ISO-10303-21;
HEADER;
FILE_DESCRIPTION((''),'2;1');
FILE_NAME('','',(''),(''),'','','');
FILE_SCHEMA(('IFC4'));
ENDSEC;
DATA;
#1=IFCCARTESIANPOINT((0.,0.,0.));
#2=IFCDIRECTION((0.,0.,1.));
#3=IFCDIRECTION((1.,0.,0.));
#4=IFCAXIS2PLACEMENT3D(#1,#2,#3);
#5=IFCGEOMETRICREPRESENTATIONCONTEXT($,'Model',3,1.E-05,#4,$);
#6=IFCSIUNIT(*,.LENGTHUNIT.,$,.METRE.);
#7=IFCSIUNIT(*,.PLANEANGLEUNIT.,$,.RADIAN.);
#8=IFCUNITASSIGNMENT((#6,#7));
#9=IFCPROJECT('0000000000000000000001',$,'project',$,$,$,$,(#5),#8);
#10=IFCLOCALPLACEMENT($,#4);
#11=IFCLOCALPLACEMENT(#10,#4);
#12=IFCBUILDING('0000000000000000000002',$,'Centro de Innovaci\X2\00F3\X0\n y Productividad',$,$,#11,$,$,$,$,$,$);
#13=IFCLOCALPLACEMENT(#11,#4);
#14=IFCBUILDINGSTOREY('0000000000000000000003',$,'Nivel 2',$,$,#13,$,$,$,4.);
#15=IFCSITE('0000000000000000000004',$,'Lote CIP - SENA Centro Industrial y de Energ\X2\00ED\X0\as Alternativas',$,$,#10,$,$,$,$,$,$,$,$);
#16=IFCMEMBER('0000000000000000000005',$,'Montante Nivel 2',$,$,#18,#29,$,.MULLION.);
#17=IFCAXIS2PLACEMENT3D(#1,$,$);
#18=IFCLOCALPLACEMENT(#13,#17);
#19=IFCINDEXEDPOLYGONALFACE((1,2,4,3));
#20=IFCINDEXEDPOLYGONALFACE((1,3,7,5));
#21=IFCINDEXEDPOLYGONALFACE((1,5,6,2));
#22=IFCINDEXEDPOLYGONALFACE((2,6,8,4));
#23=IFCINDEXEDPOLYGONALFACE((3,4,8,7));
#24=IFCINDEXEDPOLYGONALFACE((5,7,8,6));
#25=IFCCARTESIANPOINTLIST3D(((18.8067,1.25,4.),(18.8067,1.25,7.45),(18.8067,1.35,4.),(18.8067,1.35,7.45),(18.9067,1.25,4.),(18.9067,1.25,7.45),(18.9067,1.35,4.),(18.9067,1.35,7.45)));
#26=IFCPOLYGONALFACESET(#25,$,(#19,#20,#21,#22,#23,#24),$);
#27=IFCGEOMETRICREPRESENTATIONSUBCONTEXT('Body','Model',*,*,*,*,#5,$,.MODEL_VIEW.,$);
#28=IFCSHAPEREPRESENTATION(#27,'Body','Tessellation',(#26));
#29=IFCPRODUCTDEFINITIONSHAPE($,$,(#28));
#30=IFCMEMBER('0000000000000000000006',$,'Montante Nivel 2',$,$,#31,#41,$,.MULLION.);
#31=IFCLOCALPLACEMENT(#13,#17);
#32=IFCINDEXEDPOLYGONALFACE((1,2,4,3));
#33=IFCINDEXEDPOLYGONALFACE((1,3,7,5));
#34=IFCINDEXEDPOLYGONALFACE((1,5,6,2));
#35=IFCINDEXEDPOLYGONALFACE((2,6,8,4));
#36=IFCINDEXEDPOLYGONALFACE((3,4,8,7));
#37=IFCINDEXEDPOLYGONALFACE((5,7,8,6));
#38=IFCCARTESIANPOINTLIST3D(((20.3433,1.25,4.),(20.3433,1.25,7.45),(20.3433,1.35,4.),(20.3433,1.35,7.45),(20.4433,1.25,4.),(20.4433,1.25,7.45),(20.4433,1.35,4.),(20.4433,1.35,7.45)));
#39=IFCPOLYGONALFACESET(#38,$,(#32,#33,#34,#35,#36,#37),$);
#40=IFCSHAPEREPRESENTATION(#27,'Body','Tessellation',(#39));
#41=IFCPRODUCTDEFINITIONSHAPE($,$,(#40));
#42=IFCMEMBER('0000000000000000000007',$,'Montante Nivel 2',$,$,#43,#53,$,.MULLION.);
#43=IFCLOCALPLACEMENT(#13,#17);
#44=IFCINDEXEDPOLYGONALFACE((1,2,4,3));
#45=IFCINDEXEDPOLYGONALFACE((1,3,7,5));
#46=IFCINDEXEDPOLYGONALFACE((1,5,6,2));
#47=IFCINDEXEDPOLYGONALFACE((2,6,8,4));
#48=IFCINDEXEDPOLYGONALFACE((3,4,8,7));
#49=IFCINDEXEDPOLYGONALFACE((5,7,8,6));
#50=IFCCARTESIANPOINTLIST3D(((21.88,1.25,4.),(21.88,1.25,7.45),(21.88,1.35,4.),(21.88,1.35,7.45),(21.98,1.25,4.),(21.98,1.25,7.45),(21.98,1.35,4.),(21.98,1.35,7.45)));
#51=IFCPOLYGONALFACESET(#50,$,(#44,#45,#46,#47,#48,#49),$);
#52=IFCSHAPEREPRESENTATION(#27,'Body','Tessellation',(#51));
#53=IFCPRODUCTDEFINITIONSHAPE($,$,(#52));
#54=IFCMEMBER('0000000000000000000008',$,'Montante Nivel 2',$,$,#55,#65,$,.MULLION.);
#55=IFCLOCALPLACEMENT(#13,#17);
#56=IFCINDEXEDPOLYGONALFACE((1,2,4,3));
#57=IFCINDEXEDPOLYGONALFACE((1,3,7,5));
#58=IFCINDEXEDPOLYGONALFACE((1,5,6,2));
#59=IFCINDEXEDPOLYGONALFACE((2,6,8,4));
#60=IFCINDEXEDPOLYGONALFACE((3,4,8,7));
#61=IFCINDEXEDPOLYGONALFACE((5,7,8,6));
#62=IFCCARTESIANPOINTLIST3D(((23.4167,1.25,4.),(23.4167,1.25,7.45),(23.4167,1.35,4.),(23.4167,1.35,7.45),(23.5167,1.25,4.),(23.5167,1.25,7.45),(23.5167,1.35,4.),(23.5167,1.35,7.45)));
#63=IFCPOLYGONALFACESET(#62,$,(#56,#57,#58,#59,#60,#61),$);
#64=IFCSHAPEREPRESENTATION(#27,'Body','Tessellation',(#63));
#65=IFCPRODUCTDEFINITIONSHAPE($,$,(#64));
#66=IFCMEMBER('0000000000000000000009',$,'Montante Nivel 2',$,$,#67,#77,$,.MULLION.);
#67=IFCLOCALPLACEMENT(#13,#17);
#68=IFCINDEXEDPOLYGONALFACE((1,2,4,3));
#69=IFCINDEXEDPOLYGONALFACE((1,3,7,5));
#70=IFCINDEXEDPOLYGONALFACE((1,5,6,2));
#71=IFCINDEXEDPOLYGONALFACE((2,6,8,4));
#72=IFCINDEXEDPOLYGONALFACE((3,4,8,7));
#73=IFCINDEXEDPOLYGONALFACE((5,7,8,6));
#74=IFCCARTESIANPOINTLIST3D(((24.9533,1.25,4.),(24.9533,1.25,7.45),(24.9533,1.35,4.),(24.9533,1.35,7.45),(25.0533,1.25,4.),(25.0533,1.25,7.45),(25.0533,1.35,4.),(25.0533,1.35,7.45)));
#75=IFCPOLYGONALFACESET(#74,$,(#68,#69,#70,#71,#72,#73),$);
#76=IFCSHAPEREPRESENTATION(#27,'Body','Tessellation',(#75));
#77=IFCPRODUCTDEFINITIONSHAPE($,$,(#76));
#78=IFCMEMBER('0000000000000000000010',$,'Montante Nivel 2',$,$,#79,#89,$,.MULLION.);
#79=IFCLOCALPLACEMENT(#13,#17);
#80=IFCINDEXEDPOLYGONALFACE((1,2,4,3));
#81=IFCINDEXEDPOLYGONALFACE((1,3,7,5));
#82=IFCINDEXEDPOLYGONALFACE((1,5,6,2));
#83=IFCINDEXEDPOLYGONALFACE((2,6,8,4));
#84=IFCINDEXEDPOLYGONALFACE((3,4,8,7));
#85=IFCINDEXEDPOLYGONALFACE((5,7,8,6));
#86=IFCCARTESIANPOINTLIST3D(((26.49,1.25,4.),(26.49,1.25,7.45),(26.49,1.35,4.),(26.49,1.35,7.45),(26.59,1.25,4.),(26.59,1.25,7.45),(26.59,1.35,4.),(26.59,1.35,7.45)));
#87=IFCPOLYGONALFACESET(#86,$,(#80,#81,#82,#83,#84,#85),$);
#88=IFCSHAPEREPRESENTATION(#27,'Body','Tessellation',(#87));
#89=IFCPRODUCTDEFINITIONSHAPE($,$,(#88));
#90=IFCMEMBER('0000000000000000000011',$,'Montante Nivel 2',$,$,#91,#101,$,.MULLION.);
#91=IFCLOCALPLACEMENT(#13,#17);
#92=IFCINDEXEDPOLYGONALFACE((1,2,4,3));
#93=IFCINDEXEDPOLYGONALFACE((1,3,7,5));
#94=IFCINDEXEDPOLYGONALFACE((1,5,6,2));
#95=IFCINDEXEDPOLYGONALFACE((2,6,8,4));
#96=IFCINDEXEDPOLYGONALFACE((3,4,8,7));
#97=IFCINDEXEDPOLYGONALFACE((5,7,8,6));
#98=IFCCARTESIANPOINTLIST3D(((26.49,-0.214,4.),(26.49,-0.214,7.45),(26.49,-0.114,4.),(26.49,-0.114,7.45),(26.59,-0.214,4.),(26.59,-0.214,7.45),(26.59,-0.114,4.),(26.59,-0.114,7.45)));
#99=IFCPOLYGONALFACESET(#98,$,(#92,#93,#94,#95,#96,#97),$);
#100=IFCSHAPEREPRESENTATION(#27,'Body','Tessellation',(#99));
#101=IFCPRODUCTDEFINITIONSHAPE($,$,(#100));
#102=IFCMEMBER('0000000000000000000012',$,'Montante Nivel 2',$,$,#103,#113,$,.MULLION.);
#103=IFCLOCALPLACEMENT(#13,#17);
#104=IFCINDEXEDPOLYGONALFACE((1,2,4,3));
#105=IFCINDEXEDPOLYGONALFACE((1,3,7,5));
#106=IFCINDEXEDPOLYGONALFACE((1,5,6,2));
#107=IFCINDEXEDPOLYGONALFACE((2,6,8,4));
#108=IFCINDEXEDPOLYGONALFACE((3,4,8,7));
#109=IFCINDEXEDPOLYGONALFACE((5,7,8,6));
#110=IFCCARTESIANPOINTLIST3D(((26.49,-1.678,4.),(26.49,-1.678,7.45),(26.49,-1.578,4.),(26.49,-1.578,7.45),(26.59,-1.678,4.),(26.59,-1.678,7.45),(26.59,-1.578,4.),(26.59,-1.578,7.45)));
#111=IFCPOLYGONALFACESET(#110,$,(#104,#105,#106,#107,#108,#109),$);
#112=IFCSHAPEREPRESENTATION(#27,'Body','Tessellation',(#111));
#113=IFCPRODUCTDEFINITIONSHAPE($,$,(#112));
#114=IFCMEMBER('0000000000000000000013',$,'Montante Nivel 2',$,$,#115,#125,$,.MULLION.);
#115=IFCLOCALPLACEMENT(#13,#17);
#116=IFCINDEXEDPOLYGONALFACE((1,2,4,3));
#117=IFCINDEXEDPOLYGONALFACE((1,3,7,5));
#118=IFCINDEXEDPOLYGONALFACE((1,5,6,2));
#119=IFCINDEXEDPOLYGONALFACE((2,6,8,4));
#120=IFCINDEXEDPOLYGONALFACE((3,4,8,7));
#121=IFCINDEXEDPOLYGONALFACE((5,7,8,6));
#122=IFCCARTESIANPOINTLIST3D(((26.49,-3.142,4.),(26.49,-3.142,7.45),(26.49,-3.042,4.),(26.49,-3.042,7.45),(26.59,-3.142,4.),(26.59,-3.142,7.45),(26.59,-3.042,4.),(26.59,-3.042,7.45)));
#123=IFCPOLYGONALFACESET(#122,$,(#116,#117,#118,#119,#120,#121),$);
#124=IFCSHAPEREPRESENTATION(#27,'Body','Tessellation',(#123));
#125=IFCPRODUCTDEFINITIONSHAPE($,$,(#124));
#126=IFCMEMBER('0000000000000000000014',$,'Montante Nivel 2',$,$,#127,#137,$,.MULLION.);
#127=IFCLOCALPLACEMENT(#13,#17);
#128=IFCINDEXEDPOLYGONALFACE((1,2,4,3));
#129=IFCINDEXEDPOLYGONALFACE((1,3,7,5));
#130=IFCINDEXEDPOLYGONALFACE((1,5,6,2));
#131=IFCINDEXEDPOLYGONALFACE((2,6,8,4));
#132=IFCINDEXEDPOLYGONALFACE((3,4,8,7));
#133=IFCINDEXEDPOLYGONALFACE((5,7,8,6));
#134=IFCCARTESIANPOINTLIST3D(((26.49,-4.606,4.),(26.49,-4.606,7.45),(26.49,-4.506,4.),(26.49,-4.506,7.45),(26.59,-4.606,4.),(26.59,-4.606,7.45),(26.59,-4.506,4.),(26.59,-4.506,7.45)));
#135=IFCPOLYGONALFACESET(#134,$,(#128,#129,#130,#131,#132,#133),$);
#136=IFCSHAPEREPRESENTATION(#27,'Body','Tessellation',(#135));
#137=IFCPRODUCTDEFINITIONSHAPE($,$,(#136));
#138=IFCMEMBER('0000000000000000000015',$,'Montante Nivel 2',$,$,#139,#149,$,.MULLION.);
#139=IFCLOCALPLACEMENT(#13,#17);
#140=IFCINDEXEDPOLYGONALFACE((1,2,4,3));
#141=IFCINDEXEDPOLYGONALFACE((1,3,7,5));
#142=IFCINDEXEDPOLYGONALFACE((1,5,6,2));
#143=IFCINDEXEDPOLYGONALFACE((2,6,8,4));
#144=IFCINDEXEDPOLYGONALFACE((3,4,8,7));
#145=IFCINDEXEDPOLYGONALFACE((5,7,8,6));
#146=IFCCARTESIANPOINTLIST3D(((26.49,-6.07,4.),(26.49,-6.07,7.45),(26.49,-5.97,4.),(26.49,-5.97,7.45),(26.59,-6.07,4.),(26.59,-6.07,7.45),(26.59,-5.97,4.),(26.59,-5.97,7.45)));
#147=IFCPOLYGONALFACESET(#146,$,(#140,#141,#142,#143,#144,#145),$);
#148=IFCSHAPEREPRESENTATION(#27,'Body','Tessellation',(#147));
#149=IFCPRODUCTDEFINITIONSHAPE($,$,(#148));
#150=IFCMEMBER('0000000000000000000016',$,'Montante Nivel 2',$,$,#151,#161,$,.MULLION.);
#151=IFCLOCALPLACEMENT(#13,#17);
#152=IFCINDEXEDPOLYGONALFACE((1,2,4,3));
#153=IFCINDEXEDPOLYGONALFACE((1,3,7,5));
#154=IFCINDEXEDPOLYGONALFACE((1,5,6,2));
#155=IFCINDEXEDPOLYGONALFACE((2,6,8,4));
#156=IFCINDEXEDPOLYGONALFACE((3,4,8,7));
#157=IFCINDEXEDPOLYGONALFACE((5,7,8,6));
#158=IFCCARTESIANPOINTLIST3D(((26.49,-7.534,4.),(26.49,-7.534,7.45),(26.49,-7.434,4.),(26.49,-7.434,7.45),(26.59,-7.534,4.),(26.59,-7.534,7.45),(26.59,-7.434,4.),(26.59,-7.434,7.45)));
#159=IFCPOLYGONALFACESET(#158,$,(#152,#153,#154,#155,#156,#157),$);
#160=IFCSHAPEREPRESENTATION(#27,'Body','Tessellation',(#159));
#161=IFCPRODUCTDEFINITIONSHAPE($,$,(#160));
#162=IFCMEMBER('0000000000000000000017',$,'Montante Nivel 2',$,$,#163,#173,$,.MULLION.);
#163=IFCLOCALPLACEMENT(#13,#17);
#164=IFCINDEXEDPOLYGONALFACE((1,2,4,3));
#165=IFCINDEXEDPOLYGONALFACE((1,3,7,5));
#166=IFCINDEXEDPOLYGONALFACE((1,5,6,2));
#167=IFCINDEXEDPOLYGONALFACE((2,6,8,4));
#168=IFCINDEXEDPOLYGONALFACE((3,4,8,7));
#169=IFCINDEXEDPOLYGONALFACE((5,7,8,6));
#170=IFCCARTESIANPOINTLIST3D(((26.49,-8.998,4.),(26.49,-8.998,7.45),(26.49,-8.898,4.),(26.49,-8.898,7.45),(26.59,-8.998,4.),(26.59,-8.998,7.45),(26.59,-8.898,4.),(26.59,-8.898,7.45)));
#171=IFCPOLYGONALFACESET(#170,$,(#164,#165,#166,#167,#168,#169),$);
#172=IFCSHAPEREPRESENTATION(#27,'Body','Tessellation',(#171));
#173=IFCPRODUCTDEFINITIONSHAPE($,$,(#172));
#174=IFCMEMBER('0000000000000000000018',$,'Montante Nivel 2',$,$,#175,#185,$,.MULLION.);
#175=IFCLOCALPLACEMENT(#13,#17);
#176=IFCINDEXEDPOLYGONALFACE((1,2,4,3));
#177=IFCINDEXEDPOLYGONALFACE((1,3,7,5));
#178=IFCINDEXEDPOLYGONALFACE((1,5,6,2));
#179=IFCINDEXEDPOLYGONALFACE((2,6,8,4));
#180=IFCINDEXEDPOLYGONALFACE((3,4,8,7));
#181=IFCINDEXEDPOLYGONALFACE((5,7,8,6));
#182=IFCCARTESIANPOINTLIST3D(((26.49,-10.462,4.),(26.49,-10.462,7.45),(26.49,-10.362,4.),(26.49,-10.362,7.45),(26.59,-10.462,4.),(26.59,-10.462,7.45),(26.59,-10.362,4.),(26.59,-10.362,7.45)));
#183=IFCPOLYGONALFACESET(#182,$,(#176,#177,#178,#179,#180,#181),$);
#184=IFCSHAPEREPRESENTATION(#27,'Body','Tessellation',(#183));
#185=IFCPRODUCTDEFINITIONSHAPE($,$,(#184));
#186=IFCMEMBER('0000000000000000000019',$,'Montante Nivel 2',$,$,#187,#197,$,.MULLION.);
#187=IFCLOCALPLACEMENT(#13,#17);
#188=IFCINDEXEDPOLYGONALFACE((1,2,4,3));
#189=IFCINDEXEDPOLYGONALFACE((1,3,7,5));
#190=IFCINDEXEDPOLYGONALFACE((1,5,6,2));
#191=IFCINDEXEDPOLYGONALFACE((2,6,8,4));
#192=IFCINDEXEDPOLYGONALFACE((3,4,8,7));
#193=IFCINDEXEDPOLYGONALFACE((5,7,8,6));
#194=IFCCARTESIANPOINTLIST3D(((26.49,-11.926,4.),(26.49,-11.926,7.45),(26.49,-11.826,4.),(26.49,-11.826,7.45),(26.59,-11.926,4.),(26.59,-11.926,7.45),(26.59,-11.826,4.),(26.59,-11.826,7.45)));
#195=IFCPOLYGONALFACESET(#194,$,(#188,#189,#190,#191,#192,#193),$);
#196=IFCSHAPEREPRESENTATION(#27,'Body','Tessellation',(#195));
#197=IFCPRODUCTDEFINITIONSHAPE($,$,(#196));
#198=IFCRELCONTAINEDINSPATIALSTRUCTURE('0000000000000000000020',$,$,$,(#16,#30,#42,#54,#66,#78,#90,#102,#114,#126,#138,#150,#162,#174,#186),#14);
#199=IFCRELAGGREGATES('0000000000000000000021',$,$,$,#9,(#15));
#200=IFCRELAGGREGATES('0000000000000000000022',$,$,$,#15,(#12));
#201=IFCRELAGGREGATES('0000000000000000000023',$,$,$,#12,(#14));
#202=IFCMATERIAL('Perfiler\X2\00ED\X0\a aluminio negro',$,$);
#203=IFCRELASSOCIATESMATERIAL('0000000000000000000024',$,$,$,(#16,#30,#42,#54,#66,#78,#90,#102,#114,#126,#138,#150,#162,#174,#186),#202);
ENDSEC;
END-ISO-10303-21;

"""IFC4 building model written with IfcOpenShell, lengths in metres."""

from ifc_helpers import new_model, si_unit, frame, origin_with_axes, place, context, subcontext, project, spatial, polyline, outline, extrude, material, element, save


model = new_model("IFC4")

# Units and contexts
model_context = context("Model", 3, precision=1e-05, world=origin_with_axes())
body_context = subcontext(model_context, "Body", "Model", "MODEL_VIEW")
ifc_project = project(units=[si_unit("LENGTHUNIT", "METRE"), si_unit("PLANEANGLEUNIT", "RADIAN")], contexts=[model_context])

# Site, building, storey
site_placement = place(None, origin_with_axes())
site = spatial("IfcSite", under=ifc_project, at=site_placement, Name="Lote CIP - SENA Centro Industrial y de Energías Alternativas")
building_placement = place(site_placement, origin_with_axes())
building = spatial("IfcBuilding", under=site, at=building_placement, Name="Centro de Innovación y Productividad")
storey_placement = place(building_placement, origin_with_axes())
storey = spatial("IfcBuildingStorey", under=building, at=storey_placement, Name="Nivel 2", Elevation=4.0)

# Members
ifc_material_1 = material(Name="Perfilería aluminio negro")
member_1_placement = place(storey_placement, origin_with_axes())
element("IfcMember", 1, at=member_1_placement, inside=storey, material=ifc_material_1, Name="Montante Nivel 2", PredefinedType="MULLION", context=body_context, shape_type="SweptSolid", body=[
    extrude(outline(polyline([(18.9067, 1.35), (18.9067, 1.25), (18.8067, 1.25), (18.8067, 1.35), (18.9067, 1.35)])), frame((0.0, 0.0, 4.0)), (0.0, 0.0, 1.0), 3.45),
])
member_2_placement = place(storey_placement, origin_with_axes())
element("IfcMember", 2, at=member_2_placement, inside=storey, material=ifc_material_1, Name="Montante Nivel 2", PredefinedType="MULLION", context=body_context, shape_type="SweptSolid", body=[
    extrude(outline(polyline([(20.4433, 1.35), (20.4433, 1.25), (20.3433, 1.25), (20.3433, 1.35), (20.4433, 1.35)])), frame((0.0, 0.0, 4.0)), (0.0, 0.0, 1.0), 3.45),
])
member_3_placement = place(storey_placement, origin_with_axes())
element("IfcMember", 3, at=member_3_placement, inside=storey, material=ifc_material_1, Name="Montante Nivel 2", PredefinedType="MULLION", context=body_context, shape_type="SweptSolid", body=[
    extrude(outline(polyline([(21.98, 1.35), (21.98, 1.25), (21.88, 1.25), (21.88, 1.35), (21.98, 1.35)])), frame((0.0, 0.0, 4.0)), (0.0, 0.0, 1.0), 3.45),
])
member_4_placement = place(storey_placement, origin_with_axes())
element("IfcMember", 4, at=member_4_placement, inside=storey, material=ifc_material_1, Name="Montante Nivel 2", PredefinedType="MULLION", context=body_context, shape_type="SweptSolid", body=[
    extrude(outline(polyline([(23.5167, 1.35), (23.5167, 1.25), (23.4167, 1.25), (23.4167, 1.35), (23.5167, 1.35)])), frame((0.0, 0.0, 4.0)), (0.0, 0.0, 1.0), 3.45),
])
member_5_placement = place(storey_placement, origin_with_axes())
element("IfcMember", 5, at=member_5_placement, inside=storey, material=ifc_material_1, Name="Montante Nivel 2", PredefinedType="MULLION", context=body_context, shape_type="SweptSolid", body=[
    extrude(outline(polyline([(25.0533, 1.35), (25.0533, 1.25), (24.9533, 1.25), (24.9533, 1.35), (25.0533, 1.35)])), frame((0.0, 0.0, 4.0)), (0.0, 0.0, 1.0), 3.45),
])
for number, where, z_axis, x_axis, name in (
    (6, (0.0, 0.0, 0.0), (0.0, 0.0, 1.0), (1.0, 0.0, 0.0), "Montante Nivel 2"),
):
    element("IfcMember", number, at=place(storey_placement, frame(where, z_axis=z_axis, x_axis=x_axis)), inside=storey, material=ifc_material_1, Name=name, PredefinedType="MULLION", context=body_context, shape_type="SweptSolid", body=[
        extrude(outline(polyline([(26.59, 1.35), (26.59, 1.25), (26.49, 1.25), (26.49, 1.35), (26.59, 1.35)])), frame((0.0, 0.0, 4.0)), (0.0, 0.0, 1.0), 3.45),
    ])
member_6_placement = place(storey_placement, origin_with_axes())
element("IfcMember", 7, at=member_6_placement, inside=storey, material=ifc_material_1, Name="Montante Nivel 2", PredefinedType="MULLION", context=body_context, shape_type="SweptSolid", body=[
    extrude(outline(polyline([(26.59, -0.114), (26.59, -0.214), (26.49, -0.214), (26.49, -0.114), (26.59, -0.114)])), frame((0.0, 0.0, 4.0)), (0.0, 0.0, 1.0), 3.45),
])
member_7_placement = place(storey_placement, origin_with_axes())
element("IfcMember", 8, at=member_7_placement, inside=storey, material=ifc_material_1, Name="Montante Nivel 2", PredefinedType="MULLION", context=body_context, shape_type="SweptSolid", body=[
    extrude(outline(polyline([(26.59, -1.578), (26.59, -1.678), (26.49, -1.678), (26.49, -1.578), (26.59, -1.578)])), frame((0.0, 0.0, 4.0)), (0.0, 0.0, 1.0), 3.45),
])
member_8_placement = place(storey_placement, origin_with_axes())
element("IfcMember", 9, at=member_8_placement, inside=storey, material=ifc_material_1, Name="Montante Nivel 2", PredefinedType="MULLION", context=body_context, shape_type="SweptSolid", body=[
    extrude(outline(polyline([(26.59, -3.042), (26.59, -3.142), (26.49, -3.142), (26.49, -3.042), (26.59, -3.042)])), frame((0.0, 0.0, 4.0)), (0.0, 0.0, 1.0), 3.45),
])
member_9_placement = place(storey_placement, origin_with_axes())
element("IfcMember", 10, at=member_9_placement, inside=storey, material=ifc_material_1, Name="Montante Nivel 2", PredefinedType="MULLION", context=body_context, shape_type="SweptSolid", body=[
    extrude(outline(polyline([(26.59, -4.506), (26.59, -4.606), (26.49, -4.606), (26.49, -4.506), (26.59, -4.506)])), frame((0.0, 0.0, 4.0)), (0.0, 0.0, 1.0), 3.45),
])
member_10_placement = place(storey_placement, origin_with_axes())
element("IfcMember", 11, at=member_10_placement, inside=storey, material=ifc_material_1, Name="Montante Nivel 2", PredefinedType="MULLION", context=body_context, shape_type="SweptSolid", body=[
    extrude(outline(polyline([(26.59, -5.97), (26.59, -6.07), (26.49, -6.07), (26.49, -5.97), (26.59, -5.97)])), frame((0.0, 0.0, 4.0)), (0.0, 0.0, 1.0), 3.45),
])
member_11_placement = place(storey_placement, origin_with_axes())
element("IfcMember", 12, at=member_11_placement, inside=storey, material=ifc_material_1, Name="Montante Nivel 2", PredefinedType="MULLION", context=body_context, shape_type="SweptSolid", body=[
    extrude(outline(polyline([(26.59, -7.434), (26.59, -7.534), (26.49, -7.534), (26.49, -7.434), (26.59, -7.434)])), frame((0.0, 0.0, 4.0)), (0.0, 0.0, 1.0), 3.45),
])
member_12_placement = place(storey_placement, origin_with_axes())
element("IfcMember", 13, at=member_12_placement, inside=storey, material=ifc_material_1, Name="Montante Nivel 2", PredefinedType="MULLION", context=body_context, shape_type="SweptSolid", body=[
    extrude(outline(polyline([(26.59, -8.898), (26.59, -8.998), (26.49, -8.998), (26.49, -8.898), (26.59, -8.898)])), frame((0.0, 0.0, 4.0)), (0.0, 0.0, 1.0), 3.45),
])
member_13_placement = place(storey_placement, origin_with_axes())
element("IfcMember", 14, at=member_13_placement, inside=storey, material=ifc_material_1, Name="Montante Nivel 2", PredefinedType="MULLION", context=body_context, shape_type="SweptSolid", body=[
    extrude(outline(polyline([(26.59, -10.362), (26.59, -10.462), (26.49, -10.462), (26.49, -10.362), (26.59, -10.362)])), frame((0.0, 0.0, 4.0)), (0.0, 0.0, 1.0), 3.45),
])
member_14_placement = place(storey_placement, origin_with_axes())
element("IfcMember", 15, at=member_14_placement, inside=storey, material=ifc_material_1, Name="Montante Nivel 2", PredefinedType="MULLION", context=body_context, shape_type="SweptSolid", body=[
    extrude(outline(polyline([(26.59, -11.826), (26.59, -11.926), (26.49, -11.926), (26.49, -11.826), (26.59, -11.826)])), frame((0.0, 0.0, 4.0)), (0.0, 0.0, 1.0), 3.45),
])

save(model, "model.ifc")
